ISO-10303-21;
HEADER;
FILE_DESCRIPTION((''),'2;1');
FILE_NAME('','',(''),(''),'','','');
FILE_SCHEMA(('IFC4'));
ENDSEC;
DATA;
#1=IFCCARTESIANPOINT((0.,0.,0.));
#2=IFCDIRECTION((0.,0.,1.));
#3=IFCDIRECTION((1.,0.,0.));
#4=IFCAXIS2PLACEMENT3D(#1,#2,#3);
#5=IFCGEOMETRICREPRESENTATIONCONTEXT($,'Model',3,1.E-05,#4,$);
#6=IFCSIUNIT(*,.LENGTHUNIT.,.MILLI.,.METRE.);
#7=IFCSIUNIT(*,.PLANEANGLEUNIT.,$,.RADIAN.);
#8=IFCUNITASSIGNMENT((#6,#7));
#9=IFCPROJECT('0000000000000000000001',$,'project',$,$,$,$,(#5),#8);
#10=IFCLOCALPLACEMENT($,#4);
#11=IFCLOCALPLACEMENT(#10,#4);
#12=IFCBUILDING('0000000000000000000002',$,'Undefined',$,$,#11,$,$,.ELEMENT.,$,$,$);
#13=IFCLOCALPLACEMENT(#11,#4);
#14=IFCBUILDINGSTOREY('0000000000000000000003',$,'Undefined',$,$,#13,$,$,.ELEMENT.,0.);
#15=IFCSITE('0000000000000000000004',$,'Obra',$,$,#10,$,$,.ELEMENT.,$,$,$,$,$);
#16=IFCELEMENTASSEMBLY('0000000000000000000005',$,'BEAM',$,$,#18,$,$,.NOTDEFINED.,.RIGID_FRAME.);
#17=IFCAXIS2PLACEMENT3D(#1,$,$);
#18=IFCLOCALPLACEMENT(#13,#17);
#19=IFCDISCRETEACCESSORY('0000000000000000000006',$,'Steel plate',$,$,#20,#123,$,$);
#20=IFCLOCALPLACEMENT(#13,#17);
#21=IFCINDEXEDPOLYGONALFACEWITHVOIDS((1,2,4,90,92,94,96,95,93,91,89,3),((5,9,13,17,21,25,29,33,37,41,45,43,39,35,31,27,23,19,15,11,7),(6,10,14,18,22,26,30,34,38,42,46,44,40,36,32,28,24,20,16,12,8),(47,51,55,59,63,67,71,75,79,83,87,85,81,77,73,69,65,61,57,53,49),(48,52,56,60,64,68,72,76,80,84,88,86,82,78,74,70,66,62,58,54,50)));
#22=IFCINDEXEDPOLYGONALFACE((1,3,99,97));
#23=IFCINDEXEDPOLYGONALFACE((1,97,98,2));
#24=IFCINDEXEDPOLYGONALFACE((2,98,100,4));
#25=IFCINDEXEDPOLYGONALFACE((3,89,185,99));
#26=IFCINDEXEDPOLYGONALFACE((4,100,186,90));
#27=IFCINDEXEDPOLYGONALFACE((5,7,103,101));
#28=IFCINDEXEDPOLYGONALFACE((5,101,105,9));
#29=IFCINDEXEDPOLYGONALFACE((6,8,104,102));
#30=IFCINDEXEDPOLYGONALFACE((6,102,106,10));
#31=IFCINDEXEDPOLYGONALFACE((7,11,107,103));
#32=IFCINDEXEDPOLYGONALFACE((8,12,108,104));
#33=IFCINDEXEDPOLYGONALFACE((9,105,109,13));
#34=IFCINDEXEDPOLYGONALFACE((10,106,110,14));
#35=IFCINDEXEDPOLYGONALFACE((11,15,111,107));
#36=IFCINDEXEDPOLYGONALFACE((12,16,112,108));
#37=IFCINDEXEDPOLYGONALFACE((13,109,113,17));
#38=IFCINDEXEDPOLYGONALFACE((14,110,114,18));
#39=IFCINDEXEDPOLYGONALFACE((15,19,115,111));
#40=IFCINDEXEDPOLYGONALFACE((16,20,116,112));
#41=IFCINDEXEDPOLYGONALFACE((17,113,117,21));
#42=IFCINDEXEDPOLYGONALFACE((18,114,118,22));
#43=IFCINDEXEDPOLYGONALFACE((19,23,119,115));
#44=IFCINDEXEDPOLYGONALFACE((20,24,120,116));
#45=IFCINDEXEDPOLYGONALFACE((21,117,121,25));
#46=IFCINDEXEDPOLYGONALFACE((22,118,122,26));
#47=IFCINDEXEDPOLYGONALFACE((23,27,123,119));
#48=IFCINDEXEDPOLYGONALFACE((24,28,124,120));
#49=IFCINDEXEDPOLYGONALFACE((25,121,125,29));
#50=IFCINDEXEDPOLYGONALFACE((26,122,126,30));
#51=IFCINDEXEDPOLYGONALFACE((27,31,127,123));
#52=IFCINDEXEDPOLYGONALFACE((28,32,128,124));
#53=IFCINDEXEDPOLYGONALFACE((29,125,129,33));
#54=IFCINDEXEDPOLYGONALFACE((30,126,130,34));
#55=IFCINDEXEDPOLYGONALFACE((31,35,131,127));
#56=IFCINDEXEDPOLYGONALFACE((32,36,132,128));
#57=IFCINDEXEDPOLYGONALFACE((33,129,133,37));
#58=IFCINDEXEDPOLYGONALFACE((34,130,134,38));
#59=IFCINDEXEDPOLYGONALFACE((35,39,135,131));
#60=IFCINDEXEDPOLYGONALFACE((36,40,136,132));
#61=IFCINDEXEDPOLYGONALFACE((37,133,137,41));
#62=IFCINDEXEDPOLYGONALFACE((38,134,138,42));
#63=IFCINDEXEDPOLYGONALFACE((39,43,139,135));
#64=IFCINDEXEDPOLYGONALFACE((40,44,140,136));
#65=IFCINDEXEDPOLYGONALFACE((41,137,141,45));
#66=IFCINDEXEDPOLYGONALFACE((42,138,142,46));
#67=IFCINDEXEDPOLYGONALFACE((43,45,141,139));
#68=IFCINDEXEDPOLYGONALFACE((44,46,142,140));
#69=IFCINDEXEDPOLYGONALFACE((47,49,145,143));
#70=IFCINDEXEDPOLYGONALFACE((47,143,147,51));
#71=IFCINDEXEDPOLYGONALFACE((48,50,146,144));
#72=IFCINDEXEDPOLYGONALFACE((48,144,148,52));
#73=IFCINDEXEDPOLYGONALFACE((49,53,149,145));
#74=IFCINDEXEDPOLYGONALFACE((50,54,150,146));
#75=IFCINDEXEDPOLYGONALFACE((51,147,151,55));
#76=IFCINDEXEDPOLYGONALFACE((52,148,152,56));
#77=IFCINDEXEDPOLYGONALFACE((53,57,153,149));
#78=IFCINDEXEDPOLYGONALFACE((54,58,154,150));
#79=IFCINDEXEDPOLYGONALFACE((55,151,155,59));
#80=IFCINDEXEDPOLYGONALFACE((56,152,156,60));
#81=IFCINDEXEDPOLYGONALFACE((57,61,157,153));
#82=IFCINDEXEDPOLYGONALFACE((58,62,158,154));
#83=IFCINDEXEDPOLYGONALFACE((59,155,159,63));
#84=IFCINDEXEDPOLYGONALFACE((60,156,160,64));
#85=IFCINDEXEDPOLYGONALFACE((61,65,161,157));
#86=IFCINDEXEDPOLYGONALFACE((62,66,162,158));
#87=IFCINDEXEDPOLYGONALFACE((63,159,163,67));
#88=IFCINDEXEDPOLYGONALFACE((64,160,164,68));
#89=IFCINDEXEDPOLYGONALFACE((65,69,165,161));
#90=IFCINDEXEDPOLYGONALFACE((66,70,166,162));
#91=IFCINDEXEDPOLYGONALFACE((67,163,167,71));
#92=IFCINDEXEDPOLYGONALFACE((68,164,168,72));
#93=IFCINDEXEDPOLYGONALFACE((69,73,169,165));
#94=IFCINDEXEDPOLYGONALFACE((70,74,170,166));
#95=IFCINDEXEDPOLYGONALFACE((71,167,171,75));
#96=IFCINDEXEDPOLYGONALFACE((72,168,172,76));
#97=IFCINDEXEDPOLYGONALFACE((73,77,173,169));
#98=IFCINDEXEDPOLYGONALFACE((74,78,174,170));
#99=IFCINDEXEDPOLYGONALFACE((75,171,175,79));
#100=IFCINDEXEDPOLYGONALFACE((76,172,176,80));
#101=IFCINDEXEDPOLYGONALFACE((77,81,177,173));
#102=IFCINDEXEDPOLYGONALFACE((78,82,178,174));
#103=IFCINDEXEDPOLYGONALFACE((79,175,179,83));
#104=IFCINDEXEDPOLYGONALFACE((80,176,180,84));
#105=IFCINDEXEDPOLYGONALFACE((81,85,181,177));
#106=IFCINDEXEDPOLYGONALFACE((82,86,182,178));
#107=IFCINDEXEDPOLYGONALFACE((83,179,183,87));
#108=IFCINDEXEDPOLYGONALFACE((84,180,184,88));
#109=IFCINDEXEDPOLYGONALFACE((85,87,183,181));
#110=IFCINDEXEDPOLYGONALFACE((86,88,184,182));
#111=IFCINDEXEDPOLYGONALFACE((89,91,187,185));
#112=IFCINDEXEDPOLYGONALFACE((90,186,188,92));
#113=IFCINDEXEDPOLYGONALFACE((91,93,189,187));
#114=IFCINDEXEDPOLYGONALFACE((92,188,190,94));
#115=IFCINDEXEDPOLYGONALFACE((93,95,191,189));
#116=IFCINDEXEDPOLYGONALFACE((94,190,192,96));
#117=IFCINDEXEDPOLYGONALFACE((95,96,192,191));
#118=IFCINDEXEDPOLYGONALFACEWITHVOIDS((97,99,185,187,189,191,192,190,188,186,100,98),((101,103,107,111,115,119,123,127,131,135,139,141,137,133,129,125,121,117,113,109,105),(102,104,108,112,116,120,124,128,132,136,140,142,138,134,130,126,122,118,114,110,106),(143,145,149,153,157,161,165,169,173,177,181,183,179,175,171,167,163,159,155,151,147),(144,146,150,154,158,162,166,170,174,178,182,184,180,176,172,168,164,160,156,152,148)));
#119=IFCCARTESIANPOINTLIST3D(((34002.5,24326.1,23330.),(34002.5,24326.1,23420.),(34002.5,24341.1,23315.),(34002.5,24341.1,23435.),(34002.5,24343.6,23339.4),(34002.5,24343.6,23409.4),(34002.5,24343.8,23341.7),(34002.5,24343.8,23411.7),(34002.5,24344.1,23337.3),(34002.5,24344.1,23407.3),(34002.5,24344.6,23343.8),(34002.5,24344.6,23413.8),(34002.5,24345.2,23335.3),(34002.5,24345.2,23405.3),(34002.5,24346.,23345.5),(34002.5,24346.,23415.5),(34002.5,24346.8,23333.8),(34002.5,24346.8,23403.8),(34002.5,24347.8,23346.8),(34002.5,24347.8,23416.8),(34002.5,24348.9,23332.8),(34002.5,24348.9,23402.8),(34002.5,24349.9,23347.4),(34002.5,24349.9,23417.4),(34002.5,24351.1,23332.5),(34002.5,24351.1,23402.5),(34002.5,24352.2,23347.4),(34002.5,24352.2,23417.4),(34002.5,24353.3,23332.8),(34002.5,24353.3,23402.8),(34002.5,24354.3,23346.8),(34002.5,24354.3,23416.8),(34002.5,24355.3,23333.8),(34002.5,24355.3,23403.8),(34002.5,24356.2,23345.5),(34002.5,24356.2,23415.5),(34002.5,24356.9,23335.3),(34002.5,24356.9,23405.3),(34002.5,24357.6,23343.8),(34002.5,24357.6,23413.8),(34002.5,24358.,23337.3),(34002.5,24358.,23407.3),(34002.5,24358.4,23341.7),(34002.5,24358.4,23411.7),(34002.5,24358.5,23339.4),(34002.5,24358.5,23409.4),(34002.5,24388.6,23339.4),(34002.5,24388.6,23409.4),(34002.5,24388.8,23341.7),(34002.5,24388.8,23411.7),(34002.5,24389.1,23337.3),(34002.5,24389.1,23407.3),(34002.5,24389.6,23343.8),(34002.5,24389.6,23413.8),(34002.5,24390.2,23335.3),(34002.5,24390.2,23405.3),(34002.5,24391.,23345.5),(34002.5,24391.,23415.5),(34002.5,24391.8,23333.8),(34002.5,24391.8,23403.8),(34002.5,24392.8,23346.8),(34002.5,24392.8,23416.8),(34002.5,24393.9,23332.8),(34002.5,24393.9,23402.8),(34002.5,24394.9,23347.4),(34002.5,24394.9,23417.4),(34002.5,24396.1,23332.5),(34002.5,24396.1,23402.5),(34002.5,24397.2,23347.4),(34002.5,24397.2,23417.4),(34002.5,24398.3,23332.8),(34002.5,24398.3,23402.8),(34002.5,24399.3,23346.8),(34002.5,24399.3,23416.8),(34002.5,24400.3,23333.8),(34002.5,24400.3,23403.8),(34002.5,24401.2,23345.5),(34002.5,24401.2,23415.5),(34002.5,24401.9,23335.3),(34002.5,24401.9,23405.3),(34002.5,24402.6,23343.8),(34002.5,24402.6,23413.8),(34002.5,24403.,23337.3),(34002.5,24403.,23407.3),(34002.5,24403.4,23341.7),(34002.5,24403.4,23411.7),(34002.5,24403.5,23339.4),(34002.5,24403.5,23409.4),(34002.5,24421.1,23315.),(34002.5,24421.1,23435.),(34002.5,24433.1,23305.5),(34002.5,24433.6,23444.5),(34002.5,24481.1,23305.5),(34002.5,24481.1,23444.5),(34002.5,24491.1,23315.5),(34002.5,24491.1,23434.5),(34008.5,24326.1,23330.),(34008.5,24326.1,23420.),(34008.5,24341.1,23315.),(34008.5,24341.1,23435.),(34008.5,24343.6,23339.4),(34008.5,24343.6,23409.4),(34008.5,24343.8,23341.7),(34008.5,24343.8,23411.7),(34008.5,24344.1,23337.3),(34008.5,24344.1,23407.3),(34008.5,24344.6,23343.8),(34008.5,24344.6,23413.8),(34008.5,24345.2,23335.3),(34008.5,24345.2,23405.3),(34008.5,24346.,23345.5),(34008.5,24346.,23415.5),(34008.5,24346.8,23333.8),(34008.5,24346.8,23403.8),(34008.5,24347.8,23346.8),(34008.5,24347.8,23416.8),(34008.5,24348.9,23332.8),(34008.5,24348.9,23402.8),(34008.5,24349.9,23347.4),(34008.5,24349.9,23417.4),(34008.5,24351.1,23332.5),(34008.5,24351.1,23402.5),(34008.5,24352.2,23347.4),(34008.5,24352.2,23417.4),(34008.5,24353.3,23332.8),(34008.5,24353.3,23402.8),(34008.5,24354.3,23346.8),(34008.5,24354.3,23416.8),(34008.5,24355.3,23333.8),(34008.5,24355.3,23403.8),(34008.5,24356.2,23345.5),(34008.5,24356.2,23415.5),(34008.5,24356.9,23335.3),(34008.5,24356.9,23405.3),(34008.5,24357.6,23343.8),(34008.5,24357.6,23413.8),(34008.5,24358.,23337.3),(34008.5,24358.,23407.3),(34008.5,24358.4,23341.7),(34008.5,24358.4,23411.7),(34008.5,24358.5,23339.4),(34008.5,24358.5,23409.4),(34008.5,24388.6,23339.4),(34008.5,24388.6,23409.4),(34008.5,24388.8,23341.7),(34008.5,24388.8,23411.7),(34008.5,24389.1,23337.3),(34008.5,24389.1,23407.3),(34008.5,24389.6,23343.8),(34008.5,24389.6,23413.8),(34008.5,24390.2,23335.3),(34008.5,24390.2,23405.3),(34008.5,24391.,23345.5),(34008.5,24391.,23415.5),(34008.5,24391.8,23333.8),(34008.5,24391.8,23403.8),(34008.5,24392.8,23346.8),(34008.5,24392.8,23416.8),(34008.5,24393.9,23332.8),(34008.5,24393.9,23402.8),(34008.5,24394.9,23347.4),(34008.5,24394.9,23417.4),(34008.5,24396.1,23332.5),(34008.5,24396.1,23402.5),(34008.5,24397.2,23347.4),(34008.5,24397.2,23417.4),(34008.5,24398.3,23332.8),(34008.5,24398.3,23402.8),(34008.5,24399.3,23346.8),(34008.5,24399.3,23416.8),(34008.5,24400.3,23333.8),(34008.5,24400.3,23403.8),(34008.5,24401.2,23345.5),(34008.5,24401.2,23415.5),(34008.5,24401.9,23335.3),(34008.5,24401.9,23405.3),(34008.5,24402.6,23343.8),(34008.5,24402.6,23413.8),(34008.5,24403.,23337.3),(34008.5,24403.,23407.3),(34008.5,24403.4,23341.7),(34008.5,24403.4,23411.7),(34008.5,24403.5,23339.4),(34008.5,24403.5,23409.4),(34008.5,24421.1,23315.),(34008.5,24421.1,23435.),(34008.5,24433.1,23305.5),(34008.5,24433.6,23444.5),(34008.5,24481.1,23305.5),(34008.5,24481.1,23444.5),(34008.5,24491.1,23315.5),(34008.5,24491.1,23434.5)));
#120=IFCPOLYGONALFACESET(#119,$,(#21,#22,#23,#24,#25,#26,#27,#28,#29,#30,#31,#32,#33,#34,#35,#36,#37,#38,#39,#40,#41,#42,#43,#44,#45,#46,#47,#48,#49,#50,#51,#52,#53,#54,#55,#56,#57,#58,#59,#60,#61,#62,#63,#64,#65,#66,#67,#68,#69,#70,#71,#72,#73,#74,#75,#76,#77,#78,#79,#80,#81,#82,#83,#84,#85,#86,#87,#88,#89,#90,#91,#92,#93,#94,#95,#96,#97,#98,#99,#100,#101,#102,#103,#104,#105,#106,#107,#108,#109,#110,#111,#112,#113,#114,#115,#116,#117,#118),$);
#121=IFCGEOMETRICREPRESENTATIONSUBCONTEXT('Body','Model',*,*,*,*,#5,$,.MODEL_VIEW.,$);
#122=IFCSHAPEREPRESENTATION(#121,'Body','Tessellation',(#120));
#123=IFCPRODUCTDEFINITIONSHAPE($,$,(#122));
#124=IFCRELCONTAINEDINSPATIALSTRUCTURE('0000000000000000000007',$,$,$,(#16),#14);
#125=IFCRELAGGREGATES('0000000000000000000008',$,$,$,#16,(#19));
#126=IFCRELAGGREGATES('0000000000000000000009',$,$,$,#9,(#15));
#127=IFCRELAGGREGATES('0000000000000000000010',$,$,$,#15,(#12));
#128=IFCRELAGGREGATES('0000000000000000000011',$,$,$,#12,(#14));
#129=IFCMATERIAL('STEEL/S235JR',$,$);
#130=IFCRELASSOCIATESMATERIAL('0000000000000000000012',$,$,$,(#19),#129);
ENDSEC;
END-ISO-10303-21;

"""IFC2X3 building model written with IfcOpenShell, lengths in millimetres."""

from ifc_helpers import new_model, si_unit, frame, origin_with_axes, origin_2d_with_axis, place, context, subcontext, project, spatial, polyline, circle, outline, extrude, source, transform, mapped, material, element, aggregate, save


model = new_model("IFC2X3")

# Units and contexts
model_context = context("Model", 3, precision=1e-05, world=origin_with_axes())
body_context = subcontext(model_context, "Body", "Model", "MODEL_VIEW")
ifc_project = project(units=[si_unit("LENGTHUNIT", "METRE", prefix="MILLI"), si_unit("PLANEANGLEUNIT", "RADIAN")], contexts=[model_context])

# Site, building, storey
site_placement = place(None, origin_with_axes())
site = spatial("IfcSite", under=ifc_project, at=site_placement, Name="Obra", CompositionType="ELEMENT")
building_placement = place(site_placement, origin_with_axes())
building = spatial("IfcBuilding", under=site, at=building_placement, Name="Undefined", CompositionType="ELEMENT")
storey_placement = place(building_placement, origin_with_axes())
storey = spatial("IfcBuildingStorey", under=building, at=storey_placement, Name="Undefined", CompositionType="ELEMENT", Elevation=0.0)

# Shared definitions
ifc_material_1 = material(Name="STEEL/S235JR")

# Element assembly
assembly_1_placement = place(storey_placement, origin_with_axes())
assembly_1 = element("IfcElementAssembly", 1, at=assembly_1_placement, inside=storey, Name="BEAM", AssemblyPlace="NOTDEFINED", PredefinedType="RIGID_FRAME")

# Discrete accessory, opening
discrete_accessory_1_placement = place(assembly_1_placement, frame((34005.5, 24491.1, 23315.5), z_axis=(-1.0, 0.0, 0.0), x_axis=(0.000001, -0.707107, -0.707107)))
discrete_accessory_1 = element("IfcDiscreteAccessory", 2, at=discrete_accessory_1_placement, material=ifc_material_1, Name="Steel plate", context=body_context, shape_type="SweptSolid", body=[
    extrude(outline(polyline([(0.0, 0.0), (14.1, 0.0), (48.1, 33.9), (49.9, 49.1), (106.4, 105.7), (106.4, 126.9), (42.8, 190.6), (21.6, 190.6), (-35.0, 134.0), (-50.6, 131.9), (-84.1, 98.3), (-84.1, 84.1), (0.0, 0.0)])), frame((0.0, 0.0, -3.0), z_axis=(0.0, 0.0, 1.0), x_axis=(1.0, 0.0, 0.0)), (0.0, 0.0, 1.0), 6.0),
])
shared_shape_1 = source(origin_with_axes(), body_context, "Body", "SweptSolid", [
    extrude(circle(Radius=7.5, at=origin_2d_with_axis()), frame((0.0, 2.4, 0.0), z_axis=(0.0, 1.0, 0.0), x_axis=(1.0, 0.0, 0.0)), (0.0, 0.0, 1.0), 6.2),
])
opening_1_placement = place(assembly_1_placement, frame((34000.0, 24373.6, 23410.0), z_axis=(0.0, -1.0, 0.0), x_axis=(0.0, 0.0, -1.0)))
element("IfcOpeningElement", 3, at=opening_1_placement, cuts=discrete_accessory_1, ObjectType="Opening", context=body_context, shape_type="MappedRepresentation", body=[
    mapped(shared_shape_1, transform((0.0, 0.0, -22.5))),
    mapped(shared_shape_1, transform((70.0, 0.0, -22.5))),
    mapped(shared_shape_1, transform((0.0, 0.0, 22.5))),
    mapped(shared_shape_1, transform((70.0, 0.0, 22.5))),
])

aggregate(assembly_1, [discrete_accessory_1])

save(model, "model.ifc")
